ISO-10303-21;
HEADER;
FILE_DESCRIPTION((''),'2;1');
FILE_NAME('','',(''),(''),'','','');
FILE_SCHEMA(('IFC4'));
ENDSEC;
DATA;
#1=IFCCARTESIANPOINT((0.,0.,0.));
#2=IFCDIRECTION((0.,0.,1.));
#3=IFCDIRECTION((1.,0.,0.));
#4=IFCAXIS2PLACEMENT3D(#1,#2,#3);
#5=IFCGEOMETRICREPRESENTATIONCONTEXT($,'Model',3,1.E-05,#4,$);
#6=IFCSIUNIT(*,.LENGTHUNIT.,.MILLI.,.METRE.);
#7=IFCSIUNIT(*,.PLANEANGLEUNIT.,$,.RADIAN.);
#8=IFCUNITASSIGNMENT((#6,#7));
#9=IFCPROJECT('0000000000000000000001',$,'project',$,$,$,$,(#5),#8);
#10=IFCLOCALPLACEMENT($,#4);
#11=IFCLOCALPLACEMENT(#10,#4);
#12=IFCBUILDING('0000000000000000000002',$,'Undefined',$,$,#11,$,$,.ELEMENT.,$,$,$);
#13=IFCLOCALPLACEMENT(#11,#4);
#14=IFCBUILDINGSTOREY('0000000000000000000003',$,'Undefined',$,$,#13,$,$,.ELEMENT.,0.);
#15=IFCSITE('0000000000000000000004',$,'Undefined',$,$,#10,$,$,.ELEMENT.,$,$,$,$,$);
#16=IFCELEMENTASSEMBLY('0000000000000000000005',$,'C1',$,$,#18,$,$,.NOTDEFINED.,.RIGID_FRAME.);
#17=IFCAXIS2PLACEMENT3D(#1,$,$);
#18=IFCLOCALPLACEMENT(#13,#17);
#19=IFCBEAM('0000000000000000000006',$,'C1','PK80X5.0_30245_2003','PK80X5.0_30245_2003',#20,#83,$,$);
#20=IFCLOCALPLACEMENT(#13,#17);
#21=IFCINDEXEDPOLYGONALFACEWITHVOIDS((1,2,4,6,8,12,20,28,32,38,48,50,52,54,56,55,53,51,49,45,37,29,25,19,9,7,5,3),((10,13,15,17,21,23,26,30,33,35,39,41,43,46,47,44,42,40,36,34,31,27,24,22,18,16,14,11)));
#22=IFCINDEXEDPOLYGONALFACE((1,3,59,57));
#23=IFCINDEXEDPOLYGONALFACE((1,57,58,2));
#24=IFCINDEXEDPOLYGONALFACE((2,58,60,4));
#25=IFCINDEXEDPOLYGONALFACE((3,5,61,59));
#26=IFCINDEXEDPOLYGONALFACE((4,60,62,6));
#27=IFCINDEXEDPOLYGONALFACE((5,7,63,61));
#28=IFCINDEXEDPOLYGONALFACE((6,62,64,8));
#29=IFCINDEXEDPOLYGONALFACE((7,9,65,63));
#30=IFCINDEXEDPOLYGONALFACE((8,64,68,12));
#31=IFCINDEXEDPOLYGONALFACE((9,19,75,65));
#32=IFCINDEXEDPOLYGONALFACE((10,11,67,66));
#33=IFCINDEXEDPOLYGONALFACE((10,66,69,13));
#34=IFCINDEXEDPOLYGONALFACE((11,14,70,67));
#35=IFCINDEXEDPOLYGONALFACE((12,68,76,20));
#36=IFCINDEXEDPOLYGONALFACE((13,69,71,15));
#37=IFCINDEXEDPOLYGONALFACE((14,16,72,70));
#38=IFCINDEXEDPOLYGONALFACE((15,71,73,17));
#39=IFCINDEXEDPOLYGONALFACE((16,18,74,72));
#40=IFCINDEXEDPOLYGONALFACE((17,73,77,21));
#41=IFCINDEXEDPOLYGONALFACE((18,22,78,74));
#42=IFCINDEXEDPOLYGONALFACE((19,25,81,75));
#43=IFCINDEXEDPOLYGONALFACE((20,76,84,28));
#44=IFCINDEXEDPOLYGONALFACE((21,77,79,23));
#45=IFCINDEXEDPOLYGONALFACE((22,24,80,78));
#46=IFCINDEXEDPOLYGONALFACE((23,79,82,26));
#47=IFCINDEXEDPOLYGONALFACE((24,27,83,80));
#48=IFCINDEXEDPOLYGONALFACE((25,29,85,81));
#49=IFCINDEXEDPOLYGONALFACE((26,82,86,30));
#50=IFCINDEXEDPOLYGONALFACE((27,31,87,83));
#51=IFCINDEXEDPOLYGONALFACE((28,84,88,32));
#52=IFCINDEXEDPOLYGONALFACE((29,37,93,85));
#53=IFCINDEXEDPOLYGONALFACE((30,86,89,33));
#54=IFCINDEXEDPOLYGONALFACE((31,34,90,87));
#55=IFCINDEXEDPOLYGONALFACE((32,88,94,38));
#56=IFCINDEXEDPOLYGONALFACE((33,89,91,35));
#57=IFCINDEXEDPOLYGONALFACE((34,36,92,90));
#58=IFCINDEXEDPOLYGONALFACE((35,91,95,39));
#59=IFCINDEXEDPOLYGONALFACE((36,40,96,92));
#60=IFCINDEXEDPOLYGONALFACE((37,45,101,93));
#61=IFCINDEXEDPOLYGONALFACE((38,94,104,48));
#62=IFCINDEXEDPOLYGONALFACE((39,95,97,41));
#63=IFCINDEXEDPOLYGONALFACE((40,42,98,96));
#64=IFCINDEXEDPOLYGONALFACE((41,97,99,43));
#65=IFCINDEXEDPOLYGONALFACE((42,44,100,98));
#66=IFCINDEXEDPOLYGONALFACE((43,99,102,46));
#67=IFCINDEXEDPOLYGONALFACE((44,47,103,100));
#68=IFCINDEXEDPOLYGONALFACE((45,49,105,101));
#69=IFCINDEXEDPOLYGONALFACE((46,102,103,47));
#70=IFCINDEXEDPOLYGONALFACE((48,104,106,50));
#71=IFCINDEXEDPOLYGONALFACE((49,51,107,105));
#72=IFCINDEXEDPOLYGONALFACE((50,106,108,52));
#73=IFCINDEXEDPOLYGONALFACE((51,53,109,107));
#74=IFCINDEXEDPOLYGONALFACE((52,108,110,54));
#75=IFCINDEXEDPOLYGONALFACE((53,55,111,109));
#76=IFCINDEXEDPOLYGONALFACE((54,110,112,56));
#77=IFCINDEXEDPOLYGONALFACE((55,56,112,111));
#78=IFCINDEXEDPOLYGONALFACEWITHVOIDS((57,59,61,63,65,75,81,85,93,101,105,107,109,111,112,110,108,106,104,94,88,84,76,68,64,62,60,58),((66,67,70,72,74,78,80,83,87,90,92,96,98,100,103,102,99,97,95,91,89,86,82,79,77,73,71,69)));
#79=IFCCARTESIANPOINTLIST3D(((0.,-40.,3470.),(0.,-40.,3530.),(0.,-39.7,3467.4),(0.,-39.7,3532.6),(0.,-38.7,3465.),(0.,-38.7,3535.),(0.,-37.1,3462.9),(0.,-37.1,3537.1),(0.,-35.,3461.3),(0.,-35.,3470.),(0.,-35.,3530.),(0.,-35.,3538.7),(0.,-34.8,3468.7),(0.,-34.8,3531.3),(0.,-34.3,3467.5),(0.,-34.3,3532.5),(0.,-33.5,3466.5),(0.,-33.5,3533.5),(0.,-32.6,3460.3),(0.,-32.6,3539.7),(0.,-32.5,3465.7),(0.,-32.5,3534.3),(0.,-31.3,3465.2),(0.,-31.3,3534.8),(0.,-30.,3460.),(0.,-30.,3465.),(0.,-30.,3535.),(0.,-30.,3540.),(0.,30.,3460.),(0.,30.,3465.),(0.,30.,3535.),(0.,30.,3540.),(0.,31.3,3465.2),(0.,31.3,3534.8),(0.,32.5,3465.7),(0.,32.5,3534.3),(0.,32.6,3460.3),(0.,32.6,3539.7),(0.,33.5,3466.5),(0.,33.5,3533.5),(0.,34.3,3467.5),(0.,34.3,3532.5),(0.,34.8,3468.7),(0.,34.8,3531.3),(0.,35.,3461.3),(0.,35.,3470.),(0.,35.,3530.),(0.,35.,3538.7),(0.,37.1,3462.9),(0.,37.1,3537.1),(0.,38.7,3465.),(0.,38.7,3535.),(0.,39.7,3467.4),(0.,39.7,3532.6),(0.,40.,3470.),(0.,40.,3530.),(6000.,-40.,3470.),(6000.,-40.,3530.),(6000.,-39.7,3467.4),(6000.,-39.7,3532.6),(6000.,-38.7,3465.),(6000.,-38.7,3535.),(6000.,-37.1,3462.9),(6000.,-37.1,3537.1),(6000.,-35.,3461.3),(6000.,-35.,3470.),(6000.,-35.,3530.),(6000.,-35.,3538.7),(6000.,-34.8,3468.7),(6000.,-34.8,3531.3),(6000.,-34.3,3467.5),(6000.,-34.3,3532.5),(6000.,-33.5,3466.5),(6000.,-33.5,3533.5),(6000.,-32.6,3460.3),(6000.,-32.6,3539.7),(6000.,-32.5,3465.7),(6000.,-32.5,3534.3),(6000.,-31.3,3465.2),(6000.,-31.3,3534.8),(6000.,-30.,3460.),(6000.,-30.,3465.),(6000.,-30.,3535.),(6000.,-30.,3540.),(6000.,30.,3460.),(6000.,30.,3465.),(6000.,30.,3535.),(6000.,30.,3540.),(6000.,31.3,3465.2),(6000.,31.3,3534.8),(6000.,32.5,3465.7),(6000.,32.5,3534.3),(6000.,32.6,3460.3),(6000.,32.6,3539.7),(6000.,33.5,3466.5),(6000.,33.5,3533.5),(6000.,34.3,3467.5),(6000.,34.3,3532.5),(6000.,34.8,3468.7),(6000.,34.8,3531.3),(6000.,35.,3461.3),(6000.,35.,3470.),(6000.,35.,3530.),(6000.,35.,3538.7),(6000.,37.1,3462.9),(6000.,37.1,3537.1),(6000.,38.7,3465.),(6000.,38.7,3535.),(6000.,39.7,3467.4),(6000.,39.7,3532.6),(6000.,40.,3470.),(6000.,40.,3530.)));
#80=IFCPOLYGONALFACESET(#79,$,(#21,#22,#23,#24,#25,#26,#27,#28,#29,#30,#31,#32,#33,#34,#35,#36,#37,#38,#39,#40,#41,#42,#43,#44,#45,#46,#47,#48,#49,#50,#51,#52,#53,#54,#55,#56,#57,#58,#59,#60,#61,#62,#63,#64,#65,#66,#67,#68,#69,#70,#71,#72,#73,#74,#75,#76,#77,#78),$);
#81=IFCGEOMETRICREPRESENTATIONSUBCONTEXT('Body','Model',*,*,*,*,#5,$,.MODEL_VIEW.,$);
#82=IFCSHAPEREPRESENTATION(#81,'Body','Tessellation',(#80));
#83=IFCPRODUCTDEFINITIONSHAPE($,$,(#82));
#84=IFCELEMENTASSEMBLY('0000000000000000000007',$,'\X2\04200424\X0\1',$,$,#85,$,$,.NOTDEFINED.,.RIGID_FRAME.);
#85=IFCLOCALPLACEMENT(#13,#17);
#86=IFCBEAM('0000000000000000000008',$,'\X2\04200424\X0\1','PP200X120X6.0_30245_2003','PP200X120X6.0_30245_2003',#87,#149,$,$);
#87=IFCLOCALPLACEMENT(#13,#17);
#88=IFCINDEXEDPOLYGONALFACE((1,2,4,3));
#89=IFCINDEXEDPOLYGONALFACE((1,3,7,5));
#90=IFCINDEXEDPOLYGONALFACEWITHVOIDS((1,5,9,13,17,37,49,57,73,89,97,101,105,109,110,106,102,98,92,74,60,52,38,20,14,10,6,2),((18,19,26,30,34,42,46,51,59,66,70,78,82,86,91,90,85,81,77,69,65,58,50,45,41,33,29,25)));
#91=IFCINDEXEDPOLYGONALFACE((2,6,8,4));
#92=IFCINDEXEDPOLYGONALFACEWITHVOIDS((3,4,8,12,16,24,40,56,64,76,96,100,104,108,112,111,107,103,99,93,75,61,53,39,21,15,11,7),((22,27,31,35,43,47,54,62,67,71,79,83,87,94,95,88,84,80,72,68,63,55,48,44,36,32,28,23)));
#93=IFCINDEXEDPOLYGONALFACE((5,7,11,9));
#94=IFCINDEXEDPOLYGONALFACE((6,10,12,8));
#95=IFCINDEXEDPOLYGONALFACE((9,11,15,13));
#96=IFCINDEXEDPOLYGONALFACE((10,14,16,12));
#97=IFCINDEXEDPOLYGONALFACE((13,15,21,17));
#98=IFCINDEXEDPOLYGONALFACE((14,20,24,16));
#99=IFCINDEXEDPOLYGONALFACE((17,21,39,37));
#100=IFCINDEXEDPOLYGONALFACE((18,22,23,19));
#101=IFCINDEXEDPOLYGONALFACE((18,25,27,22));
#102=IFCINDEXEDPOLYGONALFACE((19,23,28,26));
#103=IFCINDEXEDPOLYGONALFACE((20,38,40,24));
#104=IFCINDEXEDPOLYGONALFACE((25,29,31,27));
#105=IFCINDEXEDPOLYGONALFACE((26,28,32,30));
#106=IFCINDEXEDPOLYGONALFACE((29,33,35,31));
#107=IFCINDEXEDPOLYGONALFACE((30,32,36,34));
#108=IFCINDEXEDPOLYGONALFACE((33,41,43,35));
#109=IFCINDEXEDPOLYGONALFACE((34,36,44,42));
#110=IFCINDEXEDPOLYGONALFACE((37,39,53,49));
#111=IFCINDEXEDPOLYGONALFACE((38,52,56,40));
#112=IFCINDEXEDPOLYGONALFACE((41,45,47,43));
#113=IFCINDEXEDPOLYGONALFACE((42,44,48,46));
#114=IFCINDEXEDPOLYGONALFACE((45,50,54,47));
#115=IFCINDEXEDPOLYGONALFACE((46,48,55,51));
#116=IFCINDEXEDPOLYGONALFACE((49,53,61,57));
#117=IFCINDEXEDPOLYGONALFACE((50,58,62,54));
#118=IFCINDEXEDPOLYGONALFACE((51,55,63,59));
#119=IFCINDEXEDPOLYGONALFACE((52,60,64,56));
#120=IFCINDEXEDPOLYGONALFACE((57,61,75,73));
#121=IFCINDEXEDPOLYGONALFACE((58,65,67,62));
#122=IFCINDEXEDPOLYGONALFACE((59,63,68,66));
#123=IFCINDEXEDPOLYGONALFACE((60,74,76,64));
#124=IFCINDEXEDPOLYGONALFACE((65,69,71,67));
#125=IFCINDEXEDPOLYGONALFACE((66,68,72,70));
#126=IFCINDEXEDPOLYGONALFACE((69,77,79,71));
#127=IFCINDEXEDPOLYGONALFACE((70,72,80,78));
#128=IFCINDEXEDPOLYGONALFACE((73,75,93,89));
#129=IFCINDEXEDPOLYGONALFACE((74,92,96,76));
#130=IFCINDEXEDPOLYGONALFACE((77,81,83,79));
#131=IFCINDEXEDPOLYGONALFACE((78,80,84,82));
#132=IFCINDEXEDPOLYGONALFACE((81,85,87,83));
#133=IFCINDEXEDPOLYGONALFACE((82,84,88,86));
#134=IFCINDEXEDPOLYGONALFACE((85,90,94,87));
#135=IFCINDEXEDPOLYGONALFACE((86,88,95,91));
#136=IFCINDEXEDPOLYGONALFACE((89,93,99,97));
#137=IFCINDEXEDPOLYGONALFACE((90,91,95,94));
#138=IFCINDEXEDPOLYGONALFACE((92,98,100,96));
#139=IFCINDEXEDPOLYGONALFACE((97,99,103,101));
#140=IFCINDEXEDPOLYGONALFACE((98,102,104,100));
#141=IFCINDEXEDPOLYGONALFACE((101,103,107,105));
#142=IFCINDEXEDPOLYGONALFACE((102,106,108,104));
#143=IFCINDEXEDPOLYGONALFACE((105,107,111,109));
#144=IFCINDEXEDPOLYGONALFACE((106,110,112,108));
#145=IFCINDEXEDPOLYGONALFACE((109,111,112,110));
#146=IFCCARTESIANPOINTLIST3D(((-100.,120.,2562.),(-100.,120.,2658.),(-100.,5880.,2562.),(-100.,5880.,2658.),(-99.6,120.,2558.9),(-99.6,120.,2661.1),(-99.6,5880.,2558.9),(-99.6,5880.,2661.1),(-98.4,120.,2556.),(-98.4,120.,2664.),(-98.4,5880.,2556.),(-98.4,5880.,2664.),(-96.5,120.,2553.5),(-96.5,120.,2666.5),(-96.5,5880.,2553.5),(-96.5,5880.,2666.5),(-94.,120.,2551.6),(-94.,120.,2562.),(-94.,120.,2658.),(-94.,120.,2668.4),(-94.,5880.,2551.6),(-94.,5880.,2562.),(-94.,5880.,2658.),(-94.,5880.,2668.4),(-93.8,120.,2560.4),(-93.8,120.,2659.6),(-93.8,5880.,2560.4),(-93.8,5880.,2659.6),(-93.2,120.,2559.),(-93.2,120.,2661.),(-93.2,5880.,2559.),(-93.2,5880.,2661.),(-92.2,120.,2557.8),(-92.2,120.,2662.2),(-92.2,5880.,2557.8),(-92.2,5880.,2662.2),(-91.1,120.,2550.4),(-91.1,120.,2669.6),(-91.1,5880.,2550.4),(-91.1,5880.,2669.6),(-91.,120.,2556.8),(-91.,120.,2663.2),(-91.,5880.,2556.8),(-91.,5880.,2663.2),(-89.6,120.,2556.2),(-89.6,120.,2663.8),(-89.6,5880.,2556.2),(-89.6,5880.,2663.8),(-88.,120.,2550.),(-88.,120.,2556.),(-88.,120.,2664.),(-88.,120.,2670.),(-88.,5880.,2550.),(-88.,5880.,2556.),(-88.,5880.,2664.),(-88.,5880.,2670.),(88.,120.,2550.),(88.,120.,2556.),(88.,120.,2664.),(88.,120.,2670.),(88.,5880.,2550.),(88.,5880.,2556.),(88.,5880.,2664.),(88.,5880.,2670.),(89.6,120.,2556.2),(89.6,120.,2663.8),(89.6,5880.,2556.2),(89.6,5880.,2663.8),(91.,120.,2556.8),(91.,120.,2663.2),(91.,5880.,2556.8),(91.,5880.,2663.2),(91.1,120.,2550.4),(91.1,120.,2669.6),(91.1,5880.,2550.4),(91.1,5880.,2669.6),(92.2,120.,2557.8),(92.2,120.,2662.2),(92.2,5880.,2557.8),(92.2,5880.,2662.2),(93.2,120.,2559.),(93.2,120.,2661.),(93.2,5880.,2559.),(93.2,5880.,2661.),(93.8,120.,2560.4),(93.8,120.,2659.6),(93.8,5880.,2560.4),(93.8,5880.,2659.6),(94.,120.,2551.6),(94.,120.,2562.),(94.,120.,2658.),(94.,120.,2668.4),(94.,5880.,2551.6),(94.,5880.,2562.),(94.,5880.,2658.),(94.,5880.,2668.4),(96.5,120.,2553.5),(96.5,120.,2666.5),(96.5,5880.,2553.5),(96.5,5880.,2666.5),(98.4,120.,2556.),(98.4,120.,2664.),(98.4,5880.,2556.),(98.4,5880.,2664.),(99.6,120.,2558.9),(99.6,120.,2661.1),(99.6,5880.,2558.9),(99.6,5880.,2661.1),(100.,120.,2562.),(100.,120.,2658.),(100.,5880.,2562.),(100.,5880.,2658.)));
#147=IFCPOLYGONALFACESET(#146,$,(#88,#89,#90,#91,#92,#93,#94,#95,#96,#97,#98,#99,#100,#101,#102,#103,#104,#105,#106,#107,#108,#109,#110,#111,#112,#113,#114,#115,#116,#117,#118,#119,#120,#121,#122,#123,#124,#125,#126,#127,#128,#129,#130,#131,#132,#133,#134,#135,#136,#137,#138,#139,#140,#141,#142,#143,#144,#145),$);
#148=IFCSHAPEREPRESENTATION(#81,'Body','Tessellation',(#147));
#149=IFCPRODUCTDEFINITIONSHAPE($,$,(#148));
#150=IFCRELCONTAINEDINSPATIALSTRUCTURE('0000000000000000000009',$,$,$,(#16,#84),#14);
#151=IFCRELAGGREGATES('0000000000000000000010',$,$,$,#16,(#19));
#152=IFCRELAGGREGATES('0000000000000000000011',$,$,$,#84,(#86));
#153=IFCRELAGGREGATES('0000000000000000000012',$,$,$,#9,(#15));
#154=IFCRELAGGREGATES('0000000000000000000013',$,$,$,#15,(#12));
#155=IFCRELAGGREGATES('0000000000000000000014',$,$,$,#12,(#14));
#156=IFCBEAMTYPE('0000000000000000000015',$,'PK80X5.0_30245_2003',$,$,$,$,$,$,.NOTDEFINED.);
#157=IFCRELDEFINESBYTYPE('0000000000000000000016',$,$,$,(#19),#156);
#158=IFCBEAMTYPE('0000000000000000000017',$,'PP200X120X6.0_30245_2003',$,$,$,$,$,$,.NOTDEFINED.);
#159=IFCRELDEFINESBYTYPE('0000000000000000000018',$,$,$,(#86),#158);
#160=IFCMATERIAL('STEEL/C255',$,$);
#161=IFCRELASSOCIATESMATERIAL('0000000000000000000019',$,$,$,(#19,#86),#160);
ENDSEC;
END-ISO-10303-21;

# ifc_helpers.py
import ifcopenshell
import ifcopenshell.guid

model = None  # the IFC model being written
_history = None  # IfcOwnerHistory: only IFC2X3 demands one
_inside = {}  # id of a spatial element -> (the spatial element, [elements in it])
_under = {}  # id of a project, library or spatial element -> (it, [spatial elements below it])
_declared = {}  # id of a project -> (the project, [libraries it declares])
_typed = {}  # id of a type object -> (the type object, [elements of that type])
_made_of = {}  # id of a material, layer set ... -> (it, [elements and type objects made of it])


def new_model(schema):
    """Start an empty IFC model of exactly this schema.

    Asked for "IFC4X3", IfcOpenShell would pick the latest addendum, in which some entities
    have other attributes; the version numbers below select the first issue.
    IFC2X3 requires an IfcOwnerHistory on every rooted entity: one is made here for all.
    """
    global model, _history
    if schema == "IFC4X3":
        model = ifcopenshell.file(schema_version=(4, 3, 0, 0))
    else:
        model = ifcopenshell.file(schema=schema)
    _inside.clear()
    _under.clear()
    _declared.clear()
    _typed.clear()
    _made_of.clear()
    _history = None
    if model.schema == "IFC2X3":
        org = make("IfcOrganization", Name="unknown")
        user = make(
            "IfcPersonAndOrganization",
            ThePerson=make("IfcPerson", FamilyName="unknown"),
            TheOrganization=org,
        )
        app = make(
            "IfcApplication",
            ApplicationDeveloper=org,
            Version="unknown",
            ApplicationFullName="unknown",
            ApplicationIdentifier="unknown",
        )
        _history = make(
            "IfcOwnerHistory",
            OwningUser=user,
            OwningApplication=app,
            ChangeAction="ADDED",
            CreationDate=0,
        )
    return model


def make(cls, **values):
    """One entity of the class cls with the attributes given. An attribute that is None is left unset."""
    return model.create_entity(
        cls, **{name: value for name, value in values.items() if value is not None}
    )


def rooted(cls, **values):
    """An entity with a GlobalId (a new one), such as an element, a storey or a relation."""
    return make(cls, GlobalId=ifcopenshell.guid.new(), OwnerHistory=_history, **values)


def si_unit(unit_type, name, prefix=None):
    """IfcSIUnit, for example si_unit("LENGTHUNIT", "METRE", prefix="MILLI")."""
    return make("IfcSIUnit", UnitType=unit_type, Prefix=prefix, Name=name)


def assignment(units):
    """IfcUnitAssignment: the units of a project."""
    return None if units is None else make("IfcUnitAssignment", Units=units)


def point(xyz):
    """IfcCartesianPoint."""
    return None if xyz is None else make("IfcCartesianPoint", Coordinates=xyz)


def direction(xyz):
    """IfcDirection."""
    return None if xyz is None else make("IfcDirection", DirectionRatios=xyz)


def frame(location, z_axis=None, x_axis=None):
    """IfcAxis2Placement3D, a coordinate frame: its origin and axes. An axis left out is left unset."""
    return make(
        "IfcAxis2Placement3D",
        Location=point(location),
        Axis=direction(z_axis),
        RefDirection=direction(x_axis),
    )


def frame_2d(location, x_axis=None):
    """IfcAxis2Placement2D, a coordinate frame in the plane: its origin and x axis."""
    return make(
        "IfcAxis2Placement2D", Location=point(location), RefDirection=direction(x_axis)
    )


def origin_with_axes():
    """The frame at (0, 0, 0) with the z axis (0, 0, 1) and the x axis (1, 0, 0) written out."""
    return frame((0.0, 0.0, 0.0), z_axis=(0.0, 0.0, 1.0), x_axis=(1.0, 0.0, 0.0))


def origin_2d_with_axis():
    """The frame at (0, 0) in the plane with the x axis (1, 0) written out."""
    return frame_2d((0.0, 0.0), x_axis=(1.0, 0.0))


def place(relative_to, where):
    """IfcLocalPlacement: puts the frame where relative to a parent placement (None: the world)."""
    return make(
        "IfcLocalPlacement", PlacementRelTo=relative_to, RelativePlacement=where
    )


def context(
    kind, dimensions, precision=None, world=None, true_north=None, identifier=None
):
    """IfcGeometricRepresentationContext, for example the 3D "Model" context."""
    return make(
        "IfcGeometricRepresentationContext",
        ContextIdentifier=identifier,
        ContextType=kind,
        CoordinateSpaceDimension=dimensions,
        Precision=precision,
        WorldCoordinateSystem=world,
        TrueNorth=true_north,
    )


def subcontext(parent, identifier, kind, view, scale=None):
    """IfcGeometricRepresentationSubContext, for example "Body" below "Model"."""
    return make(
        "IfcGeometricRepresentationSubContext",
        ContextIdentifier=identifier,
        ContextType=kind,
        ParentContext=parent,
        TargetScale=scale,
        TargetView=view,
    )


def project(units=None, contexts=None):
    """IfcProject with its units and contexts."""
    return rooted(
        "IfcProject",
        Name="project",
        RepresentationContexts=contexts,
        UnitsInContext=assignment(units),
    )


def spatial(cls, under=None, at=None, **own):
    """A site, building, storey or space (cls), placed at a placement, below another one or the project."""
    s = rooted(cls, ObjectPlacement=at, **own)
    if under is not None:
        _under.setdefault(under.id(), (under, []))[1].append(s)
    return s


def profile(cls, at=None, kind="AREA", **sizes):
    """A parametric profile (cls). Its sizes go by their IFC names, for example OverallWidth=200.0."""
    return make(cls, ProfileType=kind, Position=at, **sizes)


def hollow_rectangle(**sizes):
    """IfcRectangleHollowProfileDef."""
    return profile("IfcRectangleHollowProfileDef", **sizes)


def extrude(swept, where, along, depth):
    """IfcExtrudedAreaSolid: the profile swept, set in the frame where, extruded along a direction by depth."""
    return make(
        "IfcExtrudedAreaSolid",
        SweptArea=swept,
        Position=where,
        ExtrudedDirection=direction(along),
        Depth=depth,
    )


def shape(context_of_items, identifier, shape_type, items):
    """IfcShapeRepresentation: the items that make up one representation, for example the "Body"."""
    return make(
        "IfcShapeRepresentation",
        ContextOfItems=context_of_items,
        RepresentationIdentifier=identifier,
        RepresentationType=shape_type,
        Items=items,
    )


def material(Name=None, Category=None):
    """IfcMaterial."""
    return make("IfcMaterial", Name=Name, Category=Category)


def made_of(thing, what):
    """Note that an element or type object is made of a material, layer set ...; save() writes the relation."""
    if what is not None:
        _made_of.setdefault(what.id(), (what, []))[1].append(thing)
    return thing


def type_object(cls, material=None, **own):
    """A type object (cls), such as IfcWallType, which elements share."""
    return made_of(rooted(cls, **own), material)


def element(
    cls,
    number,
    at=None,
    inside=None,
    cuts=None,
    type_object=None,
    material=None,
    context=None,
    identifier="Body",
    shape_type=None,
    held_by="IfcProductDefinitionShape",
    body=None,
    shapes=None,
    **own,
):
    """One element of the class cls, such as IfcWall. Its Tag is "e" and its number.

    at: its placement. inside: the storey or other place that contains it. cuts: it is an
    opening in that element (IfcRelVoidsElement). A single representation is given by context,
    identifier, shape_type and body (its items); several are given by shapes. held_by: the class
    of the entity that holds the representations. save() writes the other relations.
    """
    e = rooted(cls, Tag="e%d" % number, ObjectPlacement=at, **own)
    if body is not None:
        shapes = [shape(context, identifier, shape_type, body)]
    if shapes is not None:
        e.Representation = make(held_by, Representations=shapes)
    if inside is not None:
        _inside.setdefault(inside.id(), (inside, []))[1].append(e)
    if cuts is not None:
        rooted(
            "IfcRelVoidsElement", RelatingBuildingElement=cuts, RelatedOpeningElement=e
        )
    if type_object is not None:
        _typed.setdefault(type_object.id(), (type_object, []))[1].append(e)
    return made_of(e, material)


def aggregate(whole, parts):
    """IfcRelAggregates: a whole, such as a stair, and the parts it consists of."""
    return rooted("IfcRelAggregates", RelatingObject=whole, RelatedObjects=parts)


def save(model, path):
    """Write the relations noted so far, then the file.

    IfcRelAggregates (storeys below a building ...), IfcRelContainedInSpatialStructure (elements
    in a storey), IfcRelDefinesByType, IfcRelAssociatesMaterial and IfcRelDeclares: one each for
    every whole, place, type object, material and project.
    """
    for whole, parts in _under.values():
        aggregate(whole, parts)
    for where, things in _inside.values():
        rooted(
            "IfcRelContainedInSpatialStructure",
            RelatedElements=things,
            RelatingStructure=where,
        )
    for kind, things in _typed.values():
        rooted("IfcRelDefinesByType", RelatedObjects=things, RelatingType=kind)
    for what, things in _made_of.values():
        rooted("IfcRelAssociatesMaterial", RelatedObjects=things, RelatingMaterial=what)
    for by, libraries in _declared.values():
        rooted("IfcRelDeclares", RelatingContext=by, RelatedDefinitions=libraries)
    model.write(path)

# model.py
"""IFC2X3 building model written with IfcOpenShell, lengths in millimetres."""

from ifc_helpers import new_model, si_unit, frame, origin_with_axes, origin_2d_with_axis, place, context, subcontext, project, spatial, hollow_rectangle, extrude, material, type_object, element, aggregate, save


model = new_model("IFC2X3")

# Units and contexts
model_context = context("Model", 3, precision=1e-05, world=origin_with_axes())
body_context = subcontext(model_context, "Body", "Model", "MODEL_VIEW")
ifc_project = project(units=[si_unit("LENGTHUNIT", "METRE", prefix="MILLI"), si_unit("PLANEANGLEUNIT", "RADIAN")], contexts=[model_context])

# Site, building, storey
site_placement = place(None, origin_with_axes())
site = spatial("IfcSite", under=ifc_project, at=site_placement, Name="Undefined", CompositionType="ELEMENT")
building_placement = place(site_placement, origin_with_axes())
building = spatial("IfcBuilding", under=site, at=building_placement, Name="Undefined", CompositionType="ELEMENT")
storey_placement = place(building_placement, origin_with_axes())
storey = spatial("IfcBuildingStorey", under=building, at=storey_placement, Name="Undefined", CompositionType="ELEMENT", Elevation=0.0)

# Element assemblies, beams
ifc_material_1 = material(Name="STEEL/C255")
beam_type_1 = type_object("IfcBeamType", Name="PK80X5.0_30245_2003", PredefinedType="NOTDEFINED")
assembly_1_placement = place(storey_placement, origin_with_axes())
assembly_1 = element("IfcElementAssembly", 1, at=assembly_1_placement, inside=storey, Name="C1", AssemblyPlace="NOTDEFINED", PredefinedType="RIGID_FRAME")
beam_1_placement = place(assembly_1_placement, frame((0.0, 0.0, 3500.0), z_axis=(0.0, 0.0, -1.0), x_axis=(1.0, 0.0, 0.0)))
beam_1 = element("IfcBeam", 2, at=beam_1_placement, type_object=beam_type_1, material=ifc_material_1, Name="C1", Description="PK80X5.0_30245_2003", ObjectType="PK80X5.0_30245_2003", context=body_context, shape_type="SweptSolid", body=[
    extrude(hollow_rectangle(XDim=80.0, YDim=80.0, WallThickness=5.0, InnerFilletRadius=5.0, OuterFilletRadius=10.0, at=origin_2d_with_axis()), frame((6000.0, 0.0, 0.0), z_axis=(-1.0, 0.0, 0.0), x_axis=(0.0, -1.0, 0.0)), (0.0, 0.0, 1.0), 6000.0),
])
aggregate(assembly_1, [beam_1])
assembly_2_placement = place(storey_placement, origin_with_axes())
assembly_2 = element("IfcElementAssembly", 3, at=assembly_2_placement, inside=storey, Name="РФ1", AssemblyPlace="NOTDEFINED", PredefinedType="RIGID_FRAME")
beam_type_2 = type_object("IfcBeamType", Name="PP200X120X6.0_30245_2003", PredefinedType="NOTDEFINED")
beam_2_placement = place(assembly_2_placement, frame((0.0, 120.0, 2610.0), z_axis=(-1.0, 0.0, 0.0), x_axis=(0.0, 1.0, 0.0)))
beam_2 = element("IfcBeam", 4, at=beam_2_placement, type_object=beam_type_2, material=ifc_material_1, Name="РФ1", Description="PP200X120X6.0_30245_2003", ObjectType="PP200X120X6.0_30245_2003", context=body_context, shape_type="SweptSolid", body=[
    extrude(hollow_rectangle(XDim=120.0, YDim=200.0, WallThickness=6.0, InnerFilletRadius=6.0, OuterFilletRadius=12.0, at=origin_2d_with_axis()), frame((5760.0, 0.0, 0.0), z_axis=(-1.0, 0.0, 0.0), x_axis=(0.0, -1.0, 0.0)), (0.0, 0.0, 1.0), 5760.0),
])
aggregate(assembly_2, [beam_2])

save(model, "model.ifc")
